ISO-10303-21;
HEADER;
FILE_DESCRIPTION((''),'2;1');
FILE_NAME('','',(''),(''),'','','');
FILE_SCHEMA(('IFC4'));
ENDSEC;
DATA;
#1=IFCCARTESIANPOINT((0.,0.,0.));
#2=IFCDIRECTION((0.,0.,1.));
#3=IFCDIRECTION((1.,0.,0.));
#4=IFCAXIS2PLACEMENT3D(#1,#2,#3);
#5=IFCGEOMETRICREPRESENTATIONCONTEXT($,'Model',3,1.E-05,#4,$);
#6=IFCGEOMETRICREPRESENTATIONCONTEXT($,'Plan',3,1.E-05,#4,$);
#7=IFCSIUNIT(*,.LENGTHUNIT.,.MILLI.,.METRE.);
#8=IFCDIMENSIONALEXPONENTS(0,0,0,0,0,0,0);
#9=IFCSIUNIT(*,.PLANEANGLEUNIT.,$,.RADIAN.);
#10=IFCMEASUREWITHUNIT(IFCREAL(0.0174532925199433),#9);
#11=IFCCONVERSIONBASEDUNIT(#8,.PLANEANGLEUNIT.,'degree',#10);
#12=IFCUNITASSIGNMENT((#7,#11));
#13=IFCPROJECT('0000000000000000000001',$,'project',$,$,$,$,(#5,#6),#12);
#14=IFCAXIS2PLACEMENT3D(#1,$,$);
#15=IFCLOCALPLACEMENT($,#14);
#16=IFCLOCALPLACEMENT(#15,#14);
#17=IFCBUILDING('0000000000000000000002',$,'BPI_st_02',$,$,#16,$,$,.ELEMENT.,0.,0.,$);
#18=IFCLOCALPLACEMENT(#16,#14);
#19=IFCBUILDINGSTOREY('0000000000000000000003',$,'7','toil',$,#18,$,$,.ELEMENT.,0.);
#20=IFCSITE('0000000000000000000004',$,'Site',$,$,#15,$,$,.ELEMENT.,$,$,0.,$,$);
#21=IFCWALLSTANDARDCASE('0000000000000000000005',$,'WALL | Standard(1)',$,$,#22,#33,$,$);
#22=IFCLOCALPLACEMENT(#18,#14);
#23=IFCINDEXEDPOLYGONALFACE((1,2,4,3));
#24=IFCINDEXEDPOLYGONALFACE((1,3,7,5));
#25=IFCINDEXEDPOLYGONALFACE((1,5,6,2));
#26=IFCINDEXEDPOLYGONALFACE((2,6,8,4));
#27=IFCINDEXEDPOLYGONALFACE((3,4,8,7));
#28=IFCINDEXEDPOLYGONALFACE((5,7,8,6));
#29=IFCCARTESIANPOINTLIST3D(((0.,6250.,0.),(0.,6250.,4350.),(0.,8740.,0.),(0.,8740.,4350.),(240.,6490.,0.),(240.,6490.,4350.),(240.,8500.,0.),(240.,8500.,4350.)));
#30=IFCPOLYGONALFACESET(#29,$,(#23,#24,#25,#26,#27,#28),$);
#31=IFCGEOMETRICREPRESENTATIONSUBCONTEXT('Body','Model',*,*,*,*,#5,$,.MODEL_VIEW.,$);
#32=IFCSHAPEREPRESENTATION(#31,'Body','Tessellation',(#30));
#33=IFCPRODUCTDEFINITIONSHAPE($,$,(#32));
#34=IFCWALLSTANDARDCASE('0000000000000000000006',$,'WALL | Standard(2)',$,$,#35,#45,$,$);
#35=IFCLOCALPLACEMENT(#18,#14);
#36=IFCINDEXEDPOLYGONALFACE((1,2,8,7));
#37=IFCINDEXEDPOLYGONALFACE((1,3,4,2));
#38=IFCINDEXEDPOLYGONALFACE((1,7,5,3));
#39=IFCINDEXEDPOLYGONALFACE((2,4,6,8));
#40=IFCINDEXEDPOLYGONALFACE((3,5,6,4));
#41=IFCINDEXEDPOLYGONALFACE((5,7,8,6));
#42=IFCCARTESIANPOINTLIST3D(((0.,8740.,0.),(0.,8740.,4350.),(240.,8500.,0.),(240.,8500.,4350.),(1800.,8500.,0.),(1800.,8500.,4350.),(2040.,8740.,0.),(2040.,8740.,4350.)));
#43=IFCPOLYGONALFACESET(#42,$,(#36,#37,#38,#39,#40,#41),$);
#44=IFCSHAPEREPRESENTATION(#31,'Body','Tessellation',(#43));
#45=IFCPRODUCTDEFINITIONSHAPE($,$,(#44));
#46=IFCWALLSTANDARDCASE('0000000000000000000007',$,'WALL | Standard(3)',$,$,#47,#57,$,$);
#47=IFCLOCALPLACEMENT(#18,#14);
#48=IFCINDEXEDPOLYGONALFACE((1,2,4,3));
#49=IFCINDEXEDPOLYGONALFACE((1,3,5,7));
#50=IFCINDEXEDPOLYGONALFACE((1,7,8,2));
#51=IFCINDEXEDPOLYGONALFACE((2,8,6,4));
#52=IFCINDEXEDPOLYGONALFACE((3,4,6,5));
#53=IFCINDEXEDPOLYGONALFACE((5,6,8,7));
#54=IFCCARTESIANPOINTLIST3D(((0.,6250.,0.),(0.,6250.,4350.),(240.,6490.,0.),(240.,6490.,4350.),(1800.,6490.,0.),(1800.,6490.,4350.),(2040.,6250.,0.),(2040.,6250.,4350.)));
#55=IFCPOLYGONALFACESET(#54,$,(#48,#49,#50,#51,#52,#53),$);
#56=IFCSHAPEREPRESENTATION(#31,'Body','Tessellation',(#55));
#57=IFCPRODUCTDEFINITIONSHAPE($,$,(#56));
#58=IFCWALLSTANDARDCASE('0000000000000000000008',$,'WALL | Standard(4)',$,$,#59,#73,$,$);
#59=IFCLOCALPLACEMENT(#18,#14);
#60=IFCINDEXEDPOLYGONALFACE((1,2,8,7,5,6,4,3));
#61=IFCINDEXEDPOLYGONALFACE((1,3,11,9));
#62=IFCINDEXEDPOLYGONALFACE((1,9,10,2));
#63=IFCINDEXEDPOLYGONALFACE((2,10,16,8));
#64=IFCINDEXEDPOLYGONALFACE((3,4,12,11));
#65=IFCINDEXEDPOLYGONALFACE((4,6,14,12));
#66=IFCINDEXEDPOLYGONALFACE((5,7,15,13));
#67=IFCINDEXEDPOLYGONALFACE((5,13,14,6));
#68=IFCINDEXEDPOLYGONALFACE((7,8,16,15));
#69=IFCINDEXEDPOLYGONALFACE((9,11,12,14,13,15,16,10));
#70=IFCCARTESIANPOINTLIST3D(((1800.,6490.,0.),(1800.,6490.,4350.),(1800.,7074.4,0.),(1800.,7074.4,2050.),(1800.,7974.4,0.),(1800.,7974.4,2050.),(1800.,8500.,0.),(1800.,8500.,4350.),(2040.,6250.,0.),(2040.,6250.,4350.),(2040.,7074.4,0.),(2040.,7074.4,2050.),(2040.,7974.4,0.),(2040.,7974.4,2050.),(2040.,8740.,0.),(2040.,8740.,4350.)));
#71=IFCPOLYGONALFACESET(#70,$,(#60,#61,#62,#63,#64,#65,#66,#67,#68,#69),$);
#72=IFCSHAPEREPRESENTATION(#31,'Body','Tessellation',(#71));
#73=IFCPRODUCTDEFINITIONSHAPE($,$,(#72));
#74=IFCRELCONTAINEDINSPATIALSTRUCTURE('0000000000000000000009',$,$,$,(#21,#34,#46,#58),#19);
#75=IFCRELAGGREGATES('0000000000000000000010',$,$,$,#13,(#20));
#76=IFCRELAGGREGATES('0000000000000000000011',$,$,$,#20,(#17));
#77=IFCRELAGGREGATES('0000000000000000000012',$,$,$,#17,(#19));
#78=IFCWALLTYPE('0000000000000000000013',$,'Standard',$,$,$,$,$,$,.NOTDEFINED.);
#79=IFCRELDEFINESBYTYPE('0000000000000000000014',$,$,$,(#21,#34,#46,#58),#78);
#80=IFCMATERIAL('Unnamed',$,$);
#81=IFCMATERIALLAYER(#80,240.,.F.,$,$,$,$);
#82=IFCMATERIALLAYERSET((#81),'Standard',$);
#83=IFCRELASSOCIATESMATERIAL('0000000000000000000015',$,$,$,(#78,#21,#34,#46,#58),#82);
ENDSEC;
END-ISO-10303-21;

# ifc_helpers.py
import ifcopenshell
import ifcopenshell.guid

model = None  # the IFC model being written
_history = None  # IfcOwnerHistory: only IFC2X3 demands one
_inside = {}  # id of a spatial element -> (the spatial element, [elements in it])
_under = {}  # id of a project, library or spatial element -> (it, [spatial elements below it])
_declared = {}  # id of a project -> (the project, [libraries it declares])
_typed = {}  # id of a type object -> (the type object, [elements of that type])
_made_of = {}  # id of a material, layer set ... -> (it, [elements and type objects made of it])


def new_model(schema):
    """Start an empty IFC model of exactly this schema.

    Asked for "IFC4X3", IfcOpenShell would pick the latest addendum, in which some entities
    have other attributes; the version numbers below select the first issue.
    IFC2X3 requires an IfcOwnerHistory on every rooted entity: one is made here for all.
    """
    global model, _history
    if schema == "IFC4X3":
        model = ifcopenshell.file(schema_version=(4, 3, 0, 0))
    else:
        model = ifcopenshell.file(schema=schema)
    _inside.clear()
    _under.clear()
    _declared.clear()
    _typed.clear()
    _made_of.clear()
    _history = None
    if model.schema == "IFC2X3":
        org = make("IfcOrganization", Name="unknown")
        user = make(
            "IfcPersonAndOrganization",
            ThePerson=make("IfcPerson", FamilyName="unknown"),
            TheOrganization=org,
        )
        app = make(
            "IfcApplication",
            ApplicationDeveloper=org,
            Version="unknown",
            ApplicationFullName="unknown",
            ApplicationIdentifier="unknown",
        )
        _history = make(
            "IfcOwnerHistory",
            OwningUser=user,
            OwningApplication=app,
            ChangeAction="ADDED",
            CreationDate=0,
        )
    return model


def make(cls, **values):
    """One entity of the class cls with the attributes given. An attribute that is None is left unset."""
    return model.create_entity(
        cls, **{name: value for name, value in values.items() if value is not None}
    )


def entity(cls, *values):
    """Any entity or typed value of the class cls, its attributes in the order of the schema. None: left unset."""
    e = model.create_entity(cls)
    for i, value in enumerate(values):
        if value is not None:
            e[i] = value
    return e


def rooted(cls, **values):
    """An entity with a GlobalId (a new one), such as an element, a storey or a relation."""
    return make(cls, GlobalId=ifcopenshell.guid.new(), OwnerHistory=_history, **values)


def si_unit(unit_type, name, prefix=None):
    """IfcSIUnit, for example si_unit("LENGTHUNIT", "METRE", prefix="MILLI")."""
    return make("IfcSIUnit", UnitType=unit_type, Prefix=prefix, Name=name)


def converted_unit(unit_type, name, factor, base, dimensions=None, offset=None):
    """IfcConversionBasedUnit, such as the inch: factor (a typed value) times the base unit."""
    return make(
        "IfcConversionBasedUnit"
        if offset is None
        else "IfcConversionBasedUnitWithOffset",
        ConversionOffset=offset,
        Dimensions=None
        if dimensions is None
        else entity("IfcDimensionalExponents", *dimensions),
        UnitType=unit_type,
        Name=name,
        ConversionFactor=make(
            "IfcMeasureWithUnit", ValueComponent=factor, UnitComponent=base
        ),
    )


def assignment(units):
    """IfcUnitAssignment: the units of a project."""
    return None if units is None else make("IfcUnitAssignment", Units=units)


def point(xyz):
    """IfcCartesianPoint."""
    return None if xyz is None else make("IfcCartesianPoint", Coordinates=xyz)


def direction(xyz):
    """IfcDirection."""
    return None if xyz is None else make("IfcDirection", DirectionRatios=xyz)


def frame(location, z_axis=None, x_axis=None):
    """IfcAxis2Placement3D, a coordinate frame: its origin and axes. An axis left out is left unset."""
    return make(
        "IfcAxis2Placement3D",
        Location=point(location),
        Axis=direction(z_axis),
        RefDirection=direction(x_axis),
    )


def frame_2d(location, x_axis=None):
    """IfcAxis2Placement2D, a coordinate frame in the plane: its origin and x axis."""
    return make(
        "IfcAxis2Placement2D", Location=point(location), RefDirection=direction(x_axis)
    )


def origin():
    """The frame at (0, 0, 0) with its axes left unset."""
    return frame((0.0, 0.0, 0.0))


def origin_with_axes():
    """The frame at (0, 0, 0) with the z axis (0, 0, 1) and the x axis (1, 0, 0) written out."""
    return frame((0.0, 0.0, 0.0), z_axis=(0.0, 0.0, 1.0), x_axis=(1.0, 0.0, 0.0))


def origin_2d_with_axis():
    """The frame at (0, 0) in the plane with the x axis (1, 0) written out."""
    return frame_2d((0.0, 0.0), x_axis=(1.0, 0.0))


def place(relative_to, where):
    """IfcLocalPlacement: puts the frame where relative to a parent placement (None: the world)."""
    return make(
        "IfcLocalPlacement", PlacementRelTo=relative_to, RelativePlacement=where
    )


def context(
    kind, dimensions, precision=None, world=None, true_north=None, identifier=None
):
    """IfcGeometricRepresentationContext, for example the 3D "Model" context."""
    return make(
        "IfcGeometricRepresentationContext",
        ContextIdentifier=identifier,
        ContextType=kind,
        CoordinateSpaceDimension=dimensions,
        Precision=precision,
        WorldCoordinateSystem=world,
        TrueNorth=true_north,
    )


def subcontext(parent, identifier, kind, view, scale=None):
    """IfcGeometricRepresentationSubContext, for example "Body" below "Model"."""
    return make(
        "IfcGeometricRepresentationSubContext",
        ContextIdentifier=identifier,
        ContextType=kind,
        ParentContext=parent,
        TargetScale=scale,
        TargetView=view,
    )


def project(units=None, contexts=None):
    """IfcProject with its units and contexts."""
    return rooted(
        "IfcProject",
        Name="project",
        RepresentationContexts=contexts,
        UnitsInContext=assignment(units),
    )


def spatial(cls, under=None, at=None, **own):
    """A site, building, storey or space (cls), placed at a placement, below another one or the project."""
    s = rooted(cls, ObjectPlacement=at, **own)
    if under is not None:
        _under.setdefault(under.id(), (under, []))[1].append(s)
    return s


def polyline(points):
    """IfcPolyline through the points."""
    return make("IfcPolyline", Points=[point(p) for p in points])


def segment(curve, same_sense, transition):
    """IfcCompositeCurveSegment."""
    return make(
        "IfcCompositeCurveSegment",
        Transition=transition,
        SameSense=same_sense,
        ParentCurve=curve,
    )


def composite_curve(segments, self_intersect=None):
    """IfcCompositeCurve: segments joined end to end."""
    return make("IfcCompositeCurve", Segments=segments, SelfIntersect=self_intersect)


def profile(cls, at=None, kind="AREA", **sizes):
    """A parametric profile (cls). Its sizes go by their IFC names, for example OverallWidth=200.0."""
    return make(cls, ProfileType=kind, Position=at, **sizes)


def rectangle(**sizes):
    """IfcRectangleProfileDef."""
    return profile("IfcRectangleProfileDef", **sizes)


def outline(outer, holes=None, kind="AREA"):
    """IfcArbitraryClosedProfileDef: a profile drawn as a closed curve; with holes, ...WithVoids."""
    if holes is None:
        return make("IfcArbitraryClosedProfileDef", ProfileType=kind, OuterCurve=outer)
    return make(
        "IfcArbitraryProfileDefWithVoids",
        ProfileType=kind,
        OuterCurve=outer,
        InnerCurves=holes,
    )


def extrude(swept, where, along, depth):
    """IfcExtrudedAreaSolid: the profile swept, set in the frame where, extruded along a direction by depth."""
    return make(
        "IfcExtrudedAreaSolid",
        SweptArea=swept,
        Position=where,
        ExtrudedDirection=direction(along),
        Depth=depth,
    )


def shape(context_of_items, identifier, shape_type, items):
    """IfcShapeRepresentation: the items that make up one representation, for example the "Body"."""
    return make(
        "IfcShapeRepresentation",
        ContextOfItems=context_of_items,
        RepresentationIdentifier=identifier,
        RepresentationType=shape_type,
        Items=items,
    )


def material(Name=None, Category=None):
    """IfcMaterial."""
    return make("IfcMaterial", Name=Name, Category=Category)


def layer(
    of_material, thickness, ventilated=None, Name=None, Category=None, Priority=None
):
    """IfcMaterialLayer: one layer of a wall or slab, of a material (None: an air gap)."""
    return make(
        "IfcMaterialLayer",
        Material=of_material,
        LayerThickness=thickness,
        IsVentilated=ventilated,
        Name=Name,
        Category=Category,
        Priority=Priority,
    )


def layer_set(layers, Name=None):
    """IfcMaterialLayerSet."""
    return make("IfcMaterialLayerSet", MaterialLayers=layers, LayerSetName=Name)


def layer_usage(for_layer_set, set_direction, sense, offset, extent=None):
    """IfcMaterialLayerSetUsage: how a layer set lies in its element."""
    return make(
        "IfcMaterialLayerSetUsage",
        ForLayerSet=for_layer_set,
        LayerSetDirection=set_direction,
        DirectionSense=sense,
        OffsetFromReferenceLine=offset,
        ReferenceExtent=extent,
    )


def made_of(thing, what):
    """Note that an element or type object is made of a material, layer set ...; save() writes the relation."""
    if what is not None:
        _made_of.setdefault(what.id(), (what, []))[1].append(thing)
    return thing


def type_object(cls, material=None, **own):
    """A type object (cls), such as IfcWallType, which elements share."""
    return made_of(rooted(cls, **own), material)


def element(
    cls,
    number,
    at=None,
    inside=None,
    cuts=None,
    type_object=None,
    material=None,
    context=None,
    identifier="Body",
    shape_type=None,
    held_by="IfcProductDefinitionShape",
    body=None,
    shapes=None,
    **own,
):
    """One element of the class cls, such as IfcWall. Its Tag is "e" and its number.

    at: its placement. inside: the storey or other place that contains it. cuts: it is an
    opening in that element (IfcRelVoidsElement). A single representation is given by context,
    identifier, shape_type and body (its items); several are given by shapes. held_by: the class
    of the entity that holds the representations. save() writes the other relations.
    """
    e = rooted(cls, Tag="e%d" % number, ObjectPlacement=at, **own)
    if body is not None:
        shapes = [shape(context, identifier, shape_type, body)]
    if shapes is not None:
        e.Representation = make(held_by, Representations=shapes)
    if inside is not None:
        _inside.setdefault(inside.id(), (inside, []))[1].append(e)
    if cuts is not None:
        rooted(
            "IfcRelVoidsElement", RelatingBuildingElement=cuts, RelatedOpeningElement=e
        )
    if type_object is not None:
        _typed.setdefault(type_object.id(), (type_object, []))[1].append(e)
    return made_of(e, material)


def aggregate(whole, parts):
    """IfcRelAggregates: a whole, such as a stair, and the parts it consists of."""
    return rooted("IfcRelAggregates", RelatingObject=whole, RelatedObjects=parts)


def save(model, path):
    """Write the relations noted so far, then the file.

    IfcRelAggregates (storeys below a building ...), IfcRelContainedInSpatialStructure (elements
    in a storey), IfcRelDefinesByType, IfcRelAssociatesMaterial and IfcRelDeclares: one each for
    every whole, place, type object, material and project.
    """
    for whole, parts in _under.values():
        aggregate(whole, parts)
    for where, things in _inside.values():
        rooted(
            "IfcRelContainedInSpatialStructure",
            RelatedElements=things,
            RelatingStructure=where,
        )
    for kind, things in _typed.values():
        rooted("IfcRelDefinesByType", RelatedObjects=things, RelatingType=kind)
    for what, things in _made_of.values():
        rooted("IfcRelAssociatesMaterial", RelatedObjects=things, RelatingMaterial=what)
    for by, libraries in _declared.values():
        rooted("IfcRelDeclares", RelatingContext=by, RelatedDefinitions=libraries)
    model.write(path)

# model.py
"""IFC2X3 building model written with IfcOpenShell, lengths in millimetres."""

from ifc_helpers import new_model, entity, si_unit, converted_unit, frame, origin, origin_with_axes, origin_2d_with_axis, place, context, subcontext, project, spatial, polyline, segment, composite_curve, rectangle, outline, extrude, material, layer, layer_set, layer_usage, type_object, element, save


model = new_model("IFC2X3")

# Units and contexts
model_context = context("Model", 3, precision=1e-05, world=origin_with_axes())
plan_context = context("Plan", 3, precision=1e-05, world=origin_with_axes())
body_context = subcontext(model_context, "Body", "Model", "MODEL_VIEW")
ifc_project = project(units=[si_unit("LENGTHUNIT", "METRE", prefix="MILLI"), converted_unit("PLANEANGLEUNIT", "degree", entity("IfcReal", 0.0174532925199433), si_unit("PLANEANGLEUNIT", "RADIAN"), dimensions=[0, 0, 0, 0, 0, 0, 0])], contexts=[model_context, plan_context])

# Site, building, storey
site_placement = place(None, origin())
site = spatial("IfcSite", under=ifc_project, at=site_placement, Name="Site", CompositionType="ELEMENT", RefElevation=0.0)
building_placement = place(site_placement, origin())
building = spatial("IfcBuilding", under=site, at=building_placement, Name="BPI_st_02", CompositionType="ELEMENT", ElevationOfRefHeight=0.0, ElevationOfTerrain=0.0)
storey_placement = place(building_placement, origin())
storey = spatial("IfcBuildingStorey", under=building, at=storey_placement, Name="7", Description="toil", CompositionType="ELEMENT", Elevation=0.0)

# Shared definitions
ifc_material = material(Name="Unnamed")

# Walls
ifc_layer_1 = layer(ifc_material, 240.0, ventilated=False)
ifc_layer_set_1 = layer_set([ifc_layer_1], Name="Standard")
ifc_layer_usage_1 = layer_usage(ifc_layer_set_1, "AXIS2", "POSITIVE", -120.0)
wall_type = type_object("IfcWallType", Name="Standard", PredefinedType="NOTDEFINED", material=ifc_layer_set_1)
wall_1_placement = place(storey_placement, frame((120.0, 6370.0, 0.0), z_axis=(0.0, 0.0, 1.0), x_axis=(0.0, 1.0, 0.0)))
element("IfcWallStandardCase", 1, at=wall_1_placement, inside=storey, type_object=wall_type, material=ifc_layer_usage_1, Name="WALL | Standard(1)", context=body_context, shape_type="SweptSolid", body=[
    extrude(outline(composite_curve([segment(polyline([(-120.0, 120.0), (120.0, -120.0)]), True, "CONTINUOUS"), segment(polyline([(120.0, -120.0), (2130.0, -120.0)]), True, "CONTINUOUS"), segment(polyline([(2130.0, -120.0), (2370.0, 120.0)]), True, "CONTINUOUS"), segment(polyline([(2370.0, 120.0), (-120.0, 120.0)]), True, "CONTINUOUS")], self_intersect=False)), origin(), (0.0, 0.0, 1.0), 4350.0),
])
ifc_layer_usage_2 = layer_usage(ifc_layer_set_1, "AXIS2", "POSITIVE", -120.0)
wall_2_placement = place(storey_placement, frame((120.0, 8620.0, 0.0)))
element("IfcWallStandardCase", 2, at=wall_2_placement, inside=storey, type_object=wall_type, material=ifc_layer_usage_2, Name="WALL | Standard(2)", context=body_context, shape_type="SweptSolid", body=[
    extrude(outline(composite_curve([segment(polyline([(-120.0, 120.0), (120.0, -120.0)]), True, "CONTINUOUS"), segment(polyline([(120.0, -120.0), (1680.0, -120.0)]), True, "CONTINUOUS"), segment(polyline([(1680.0, -120.0), (1920.0, 120.0)]), True, "CONTINUOUS"), segment(polyline([(1920.0, 120.0), (-120.0, 120.0)]), True, "CONTINUOUS")], self_intersect=False)), origin(), (0.0, 0.0, 1.0), 4350.0),
])
ifc_layer_usage_3 = layer_usage(ifc_layer_set_1, "AXIS2", "POSITIVE", -120.0)
wall_3_placement = place(storey_placement, frame((120.0, 6370.0, 0.0)))
element("IfcWallStandardCase", 3, at=wall_3_placement, inside=storey, type_object=wall_type, material=ifc_layer_usage_3, Name="WALL | Standard(3)", context=body_context, shape_type="SweptSolid", body=[
    extrude(outline(composite_curve([segment(polyline([(120.0, 120.0), (-120.0, -120.0)]), True, "CONTINUOUS"), segment(polyline([(-120.0, -120.0), (1920.0, -120.0)]), True, "CONTINUOUS"), segment(polyline([(1920.0, -120.0), (1680.0, 120.0)]), True, "CONTINUOUS"), segment(polyline([(1680.0, 120.0), (120.0, 120.0)]), True, "CONTINUOUS")], self_intersect=False)), origin(), (0.0, 0.0, 1.0), 4350.0),
])

# Wall, opening
ifc_layer_usage_4 = layer_usage(ifc_layer_set_1, "AXIS2", "POSITIVE", -120.0)
wall_4_placement = place(storey_placement, frame((1920.0, 8620.0, 0.0), z_axis=(0.0, 0.0, 1.0), x_axis=(0.0, -1.0, 0.0)))
wall_4 = element("IfcWallStandardCase", 4, at=wall_4_placement, inside=storey, type_object=wall_type, material=ifc_layer_usage_4, Name="WALL | Standard(4)", context=body_context, shape_type="SweptSolid", body=[
    extrude(outline(composite_curve([segment(polyline([(-120.0, 120.0), (120.0, -120.0)]), True, "CONTINUOUS"), segment(polyline([(120.0, -120.0), (2130.0, -120.0)]), True, "CONTINUOUS"), segment(polyline([(2130.0, -120.0), (2370.0, 120.0)]), True, "CONTINUOUS"), segment(polyline([(2370.0, 120.0), (-120.0, 120.0)]), True, "CONTINUOUS")], self_intersect=False)), origin(), (0.0, 0.0, 1.0), 4350.0),
])
opening_placement = place(wall_4_placement, frame((645.6, 0.0, 0.0)))
element("IfcOpeningElement", 5, at=opening_placement, cuts=wall_4, context=body_context, shape_type="SweptSolid", body=[
    extrude(rectangle(XDim=900.0, YDim=2050.0, at=origin_2d_with_axis()), frame((450.0, 120.0, 1025.0), z_axis=(0.0, -1.0, 0.0), x_axis=(1.0, 0.0, 0.0)), (0.0, 0.0, 1.0), 240.0),
])

save(model, "model.ifc")
